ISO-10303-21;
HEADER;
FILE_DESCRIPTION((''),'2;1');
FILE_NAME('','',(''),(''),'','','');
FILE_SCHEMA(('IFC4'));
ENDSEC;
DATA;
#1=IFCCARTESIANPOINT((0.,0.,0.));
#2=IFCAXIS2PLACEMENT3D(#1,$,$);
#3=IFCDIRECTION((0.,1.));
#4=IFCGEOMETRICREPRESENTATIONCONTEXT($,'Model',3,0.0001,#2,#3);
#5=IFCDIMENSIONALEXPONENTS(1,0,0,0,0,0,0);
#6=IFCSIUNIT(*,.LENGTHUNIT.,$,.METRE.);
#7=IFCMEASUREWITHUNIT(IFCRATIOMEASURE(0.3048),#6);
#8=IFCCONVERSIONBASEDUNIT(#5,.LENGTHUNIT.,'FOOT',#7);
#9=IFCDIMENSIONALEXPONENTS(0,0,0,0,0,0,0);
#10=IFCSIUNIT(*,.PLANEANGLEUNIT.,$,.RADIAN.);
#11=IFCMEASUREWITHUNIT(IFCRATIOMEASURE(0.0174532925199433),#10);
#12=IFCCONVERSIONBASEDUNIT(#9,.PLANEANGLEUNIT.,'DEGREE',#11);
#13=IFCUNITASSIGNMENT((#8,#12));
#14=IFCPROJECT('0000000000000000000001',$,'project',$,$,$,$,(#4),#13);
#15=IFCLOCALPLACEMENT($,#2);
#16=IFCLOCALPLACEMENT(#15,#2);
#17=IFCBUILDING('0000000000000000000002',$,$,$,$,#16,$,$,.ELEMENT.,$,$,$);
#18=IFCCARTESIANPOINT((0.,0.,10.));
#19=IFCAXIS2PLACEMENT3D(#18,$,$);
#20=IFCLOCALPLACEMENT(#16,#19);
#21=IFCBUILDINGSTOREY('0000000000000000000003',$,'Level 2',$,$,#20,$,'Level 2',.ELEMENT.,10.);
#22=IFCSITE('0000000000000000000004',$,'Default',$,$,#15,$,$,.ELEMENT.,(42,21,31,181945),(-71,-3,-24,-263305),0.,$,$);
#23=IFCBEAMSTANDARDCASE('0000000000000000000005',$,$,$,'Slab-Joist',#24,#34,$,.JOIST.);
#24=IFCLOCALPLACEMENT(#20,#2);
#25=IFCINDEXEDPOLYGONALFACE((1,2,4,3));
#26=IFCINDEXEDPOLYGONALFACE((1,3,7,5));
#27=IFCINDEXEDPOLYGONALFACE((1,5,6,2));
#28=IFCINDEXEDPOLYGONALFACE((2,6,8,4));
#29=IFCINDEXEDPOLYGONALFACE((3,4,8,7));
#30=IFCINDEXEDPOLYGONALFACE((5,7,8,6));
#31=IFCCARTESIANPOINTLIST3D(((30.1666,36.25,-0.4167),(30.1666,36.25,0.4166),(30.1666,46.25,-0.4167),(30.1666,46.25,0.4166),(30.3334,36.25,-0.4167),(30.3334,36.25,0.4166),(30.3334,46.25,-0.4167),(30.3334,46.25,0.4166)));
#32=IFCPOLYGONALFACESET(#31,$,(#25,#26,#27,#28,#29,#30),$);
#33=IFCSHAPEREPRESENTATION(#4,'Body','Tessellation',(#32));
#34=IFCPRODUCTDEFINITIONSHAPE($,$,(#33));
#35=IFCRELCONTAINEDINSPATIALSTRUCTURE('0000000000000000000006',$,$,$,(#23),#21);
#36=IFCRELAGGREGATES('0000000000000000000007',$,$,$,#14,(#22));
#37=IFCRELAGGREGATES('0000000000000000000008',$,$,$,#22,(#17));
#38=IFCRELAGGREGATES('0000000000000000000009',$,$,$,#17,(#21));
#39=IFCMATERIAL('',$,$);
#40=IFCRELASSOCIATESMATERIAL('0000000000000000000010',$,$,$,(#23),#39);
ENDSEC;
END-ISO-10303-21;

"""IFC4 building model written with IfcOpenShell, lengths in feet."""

from ifc_helpers import new_model, entity, si_unit, converted_unit, direction, frame, origin, origin_with_axes, place, context, project, spatial, rectangle, extrude, material, element, save


model = new_model("IFC4")

# Units and contexts
model_context = context("Model", 3, precision=0.0001, world=origin(), true_north=direction((0.0, 1.0)))
ifc_project = project(units=[converted_unit("LENGTHUNIT", "FOOT", entity("IfcRatioMeasure", 0.3048), si_unit("LENGTHUNIT", "METRE"), dimensions=[1, 0, 0, 0, 0, 0, 0]), converted_unit("PLANEANGLEUNIT", "DEGREE", entity("IfcRatioMeasure", 0.0174532925199433), si_unit("PLANEANGLEUNIT", "RADIAN"), dimensions=[0, 0, 0, 0, 0, 0, 0])], contexts=[model_context])

# Site, building, storey
site_placement = place(None, origin())
site = spatial("IfcSite", under=ifc_project, at=site_placement, Name="Default", CompositionType="ELEMENT", RefLatitude=(42, 21, 31, 181945), RefLongitude=(-71, -3, -24, -263305), RefElevation=0.0)
building_placement = place(site_placement, origin())
building = spatial("IfcBuilding", under=site, at=building_placement, CompositionType="ELEMENT")
storey_placement = place(building_placement, frame((0.0, 0.0, 10.0)))
storey = spatial("IfcBuildingStorey", under=building, at=storey_placement, Name="Level 2", LongName="Level 2", CompositionType="ELEMENT", Elevation=10.0)

# Beam
ifc_material = material(Name="")
placement_1 = place(storey_placement, frame((30.25, 36.25, 0.0), z_axis=(0.0, 0.0, 1.0), x_axis=(1.0, 0.0, 0.0)))
beam_1_placement = place(placement_1, frame((0.0, 0.0, 0.0), z_axis=(0.0, 1.0, 0.0), x_axis=(-1.0, 0.0, 0.0)))
element("IfcBeamStandardCase", 1, at=beam_1_placement, inside=storey, material=ifc_material, ObjectType="Slab-Joist", PredefinedType="JOIST", context=model_context, shape_type="SweptSolid", body=[
    extrude(rectangle(XDim=0.1667, YDim=0.8333), origin_with_axes(), (0.0, 0.0, 1.0), 10.0),
])

save(model, "model.ifc")
